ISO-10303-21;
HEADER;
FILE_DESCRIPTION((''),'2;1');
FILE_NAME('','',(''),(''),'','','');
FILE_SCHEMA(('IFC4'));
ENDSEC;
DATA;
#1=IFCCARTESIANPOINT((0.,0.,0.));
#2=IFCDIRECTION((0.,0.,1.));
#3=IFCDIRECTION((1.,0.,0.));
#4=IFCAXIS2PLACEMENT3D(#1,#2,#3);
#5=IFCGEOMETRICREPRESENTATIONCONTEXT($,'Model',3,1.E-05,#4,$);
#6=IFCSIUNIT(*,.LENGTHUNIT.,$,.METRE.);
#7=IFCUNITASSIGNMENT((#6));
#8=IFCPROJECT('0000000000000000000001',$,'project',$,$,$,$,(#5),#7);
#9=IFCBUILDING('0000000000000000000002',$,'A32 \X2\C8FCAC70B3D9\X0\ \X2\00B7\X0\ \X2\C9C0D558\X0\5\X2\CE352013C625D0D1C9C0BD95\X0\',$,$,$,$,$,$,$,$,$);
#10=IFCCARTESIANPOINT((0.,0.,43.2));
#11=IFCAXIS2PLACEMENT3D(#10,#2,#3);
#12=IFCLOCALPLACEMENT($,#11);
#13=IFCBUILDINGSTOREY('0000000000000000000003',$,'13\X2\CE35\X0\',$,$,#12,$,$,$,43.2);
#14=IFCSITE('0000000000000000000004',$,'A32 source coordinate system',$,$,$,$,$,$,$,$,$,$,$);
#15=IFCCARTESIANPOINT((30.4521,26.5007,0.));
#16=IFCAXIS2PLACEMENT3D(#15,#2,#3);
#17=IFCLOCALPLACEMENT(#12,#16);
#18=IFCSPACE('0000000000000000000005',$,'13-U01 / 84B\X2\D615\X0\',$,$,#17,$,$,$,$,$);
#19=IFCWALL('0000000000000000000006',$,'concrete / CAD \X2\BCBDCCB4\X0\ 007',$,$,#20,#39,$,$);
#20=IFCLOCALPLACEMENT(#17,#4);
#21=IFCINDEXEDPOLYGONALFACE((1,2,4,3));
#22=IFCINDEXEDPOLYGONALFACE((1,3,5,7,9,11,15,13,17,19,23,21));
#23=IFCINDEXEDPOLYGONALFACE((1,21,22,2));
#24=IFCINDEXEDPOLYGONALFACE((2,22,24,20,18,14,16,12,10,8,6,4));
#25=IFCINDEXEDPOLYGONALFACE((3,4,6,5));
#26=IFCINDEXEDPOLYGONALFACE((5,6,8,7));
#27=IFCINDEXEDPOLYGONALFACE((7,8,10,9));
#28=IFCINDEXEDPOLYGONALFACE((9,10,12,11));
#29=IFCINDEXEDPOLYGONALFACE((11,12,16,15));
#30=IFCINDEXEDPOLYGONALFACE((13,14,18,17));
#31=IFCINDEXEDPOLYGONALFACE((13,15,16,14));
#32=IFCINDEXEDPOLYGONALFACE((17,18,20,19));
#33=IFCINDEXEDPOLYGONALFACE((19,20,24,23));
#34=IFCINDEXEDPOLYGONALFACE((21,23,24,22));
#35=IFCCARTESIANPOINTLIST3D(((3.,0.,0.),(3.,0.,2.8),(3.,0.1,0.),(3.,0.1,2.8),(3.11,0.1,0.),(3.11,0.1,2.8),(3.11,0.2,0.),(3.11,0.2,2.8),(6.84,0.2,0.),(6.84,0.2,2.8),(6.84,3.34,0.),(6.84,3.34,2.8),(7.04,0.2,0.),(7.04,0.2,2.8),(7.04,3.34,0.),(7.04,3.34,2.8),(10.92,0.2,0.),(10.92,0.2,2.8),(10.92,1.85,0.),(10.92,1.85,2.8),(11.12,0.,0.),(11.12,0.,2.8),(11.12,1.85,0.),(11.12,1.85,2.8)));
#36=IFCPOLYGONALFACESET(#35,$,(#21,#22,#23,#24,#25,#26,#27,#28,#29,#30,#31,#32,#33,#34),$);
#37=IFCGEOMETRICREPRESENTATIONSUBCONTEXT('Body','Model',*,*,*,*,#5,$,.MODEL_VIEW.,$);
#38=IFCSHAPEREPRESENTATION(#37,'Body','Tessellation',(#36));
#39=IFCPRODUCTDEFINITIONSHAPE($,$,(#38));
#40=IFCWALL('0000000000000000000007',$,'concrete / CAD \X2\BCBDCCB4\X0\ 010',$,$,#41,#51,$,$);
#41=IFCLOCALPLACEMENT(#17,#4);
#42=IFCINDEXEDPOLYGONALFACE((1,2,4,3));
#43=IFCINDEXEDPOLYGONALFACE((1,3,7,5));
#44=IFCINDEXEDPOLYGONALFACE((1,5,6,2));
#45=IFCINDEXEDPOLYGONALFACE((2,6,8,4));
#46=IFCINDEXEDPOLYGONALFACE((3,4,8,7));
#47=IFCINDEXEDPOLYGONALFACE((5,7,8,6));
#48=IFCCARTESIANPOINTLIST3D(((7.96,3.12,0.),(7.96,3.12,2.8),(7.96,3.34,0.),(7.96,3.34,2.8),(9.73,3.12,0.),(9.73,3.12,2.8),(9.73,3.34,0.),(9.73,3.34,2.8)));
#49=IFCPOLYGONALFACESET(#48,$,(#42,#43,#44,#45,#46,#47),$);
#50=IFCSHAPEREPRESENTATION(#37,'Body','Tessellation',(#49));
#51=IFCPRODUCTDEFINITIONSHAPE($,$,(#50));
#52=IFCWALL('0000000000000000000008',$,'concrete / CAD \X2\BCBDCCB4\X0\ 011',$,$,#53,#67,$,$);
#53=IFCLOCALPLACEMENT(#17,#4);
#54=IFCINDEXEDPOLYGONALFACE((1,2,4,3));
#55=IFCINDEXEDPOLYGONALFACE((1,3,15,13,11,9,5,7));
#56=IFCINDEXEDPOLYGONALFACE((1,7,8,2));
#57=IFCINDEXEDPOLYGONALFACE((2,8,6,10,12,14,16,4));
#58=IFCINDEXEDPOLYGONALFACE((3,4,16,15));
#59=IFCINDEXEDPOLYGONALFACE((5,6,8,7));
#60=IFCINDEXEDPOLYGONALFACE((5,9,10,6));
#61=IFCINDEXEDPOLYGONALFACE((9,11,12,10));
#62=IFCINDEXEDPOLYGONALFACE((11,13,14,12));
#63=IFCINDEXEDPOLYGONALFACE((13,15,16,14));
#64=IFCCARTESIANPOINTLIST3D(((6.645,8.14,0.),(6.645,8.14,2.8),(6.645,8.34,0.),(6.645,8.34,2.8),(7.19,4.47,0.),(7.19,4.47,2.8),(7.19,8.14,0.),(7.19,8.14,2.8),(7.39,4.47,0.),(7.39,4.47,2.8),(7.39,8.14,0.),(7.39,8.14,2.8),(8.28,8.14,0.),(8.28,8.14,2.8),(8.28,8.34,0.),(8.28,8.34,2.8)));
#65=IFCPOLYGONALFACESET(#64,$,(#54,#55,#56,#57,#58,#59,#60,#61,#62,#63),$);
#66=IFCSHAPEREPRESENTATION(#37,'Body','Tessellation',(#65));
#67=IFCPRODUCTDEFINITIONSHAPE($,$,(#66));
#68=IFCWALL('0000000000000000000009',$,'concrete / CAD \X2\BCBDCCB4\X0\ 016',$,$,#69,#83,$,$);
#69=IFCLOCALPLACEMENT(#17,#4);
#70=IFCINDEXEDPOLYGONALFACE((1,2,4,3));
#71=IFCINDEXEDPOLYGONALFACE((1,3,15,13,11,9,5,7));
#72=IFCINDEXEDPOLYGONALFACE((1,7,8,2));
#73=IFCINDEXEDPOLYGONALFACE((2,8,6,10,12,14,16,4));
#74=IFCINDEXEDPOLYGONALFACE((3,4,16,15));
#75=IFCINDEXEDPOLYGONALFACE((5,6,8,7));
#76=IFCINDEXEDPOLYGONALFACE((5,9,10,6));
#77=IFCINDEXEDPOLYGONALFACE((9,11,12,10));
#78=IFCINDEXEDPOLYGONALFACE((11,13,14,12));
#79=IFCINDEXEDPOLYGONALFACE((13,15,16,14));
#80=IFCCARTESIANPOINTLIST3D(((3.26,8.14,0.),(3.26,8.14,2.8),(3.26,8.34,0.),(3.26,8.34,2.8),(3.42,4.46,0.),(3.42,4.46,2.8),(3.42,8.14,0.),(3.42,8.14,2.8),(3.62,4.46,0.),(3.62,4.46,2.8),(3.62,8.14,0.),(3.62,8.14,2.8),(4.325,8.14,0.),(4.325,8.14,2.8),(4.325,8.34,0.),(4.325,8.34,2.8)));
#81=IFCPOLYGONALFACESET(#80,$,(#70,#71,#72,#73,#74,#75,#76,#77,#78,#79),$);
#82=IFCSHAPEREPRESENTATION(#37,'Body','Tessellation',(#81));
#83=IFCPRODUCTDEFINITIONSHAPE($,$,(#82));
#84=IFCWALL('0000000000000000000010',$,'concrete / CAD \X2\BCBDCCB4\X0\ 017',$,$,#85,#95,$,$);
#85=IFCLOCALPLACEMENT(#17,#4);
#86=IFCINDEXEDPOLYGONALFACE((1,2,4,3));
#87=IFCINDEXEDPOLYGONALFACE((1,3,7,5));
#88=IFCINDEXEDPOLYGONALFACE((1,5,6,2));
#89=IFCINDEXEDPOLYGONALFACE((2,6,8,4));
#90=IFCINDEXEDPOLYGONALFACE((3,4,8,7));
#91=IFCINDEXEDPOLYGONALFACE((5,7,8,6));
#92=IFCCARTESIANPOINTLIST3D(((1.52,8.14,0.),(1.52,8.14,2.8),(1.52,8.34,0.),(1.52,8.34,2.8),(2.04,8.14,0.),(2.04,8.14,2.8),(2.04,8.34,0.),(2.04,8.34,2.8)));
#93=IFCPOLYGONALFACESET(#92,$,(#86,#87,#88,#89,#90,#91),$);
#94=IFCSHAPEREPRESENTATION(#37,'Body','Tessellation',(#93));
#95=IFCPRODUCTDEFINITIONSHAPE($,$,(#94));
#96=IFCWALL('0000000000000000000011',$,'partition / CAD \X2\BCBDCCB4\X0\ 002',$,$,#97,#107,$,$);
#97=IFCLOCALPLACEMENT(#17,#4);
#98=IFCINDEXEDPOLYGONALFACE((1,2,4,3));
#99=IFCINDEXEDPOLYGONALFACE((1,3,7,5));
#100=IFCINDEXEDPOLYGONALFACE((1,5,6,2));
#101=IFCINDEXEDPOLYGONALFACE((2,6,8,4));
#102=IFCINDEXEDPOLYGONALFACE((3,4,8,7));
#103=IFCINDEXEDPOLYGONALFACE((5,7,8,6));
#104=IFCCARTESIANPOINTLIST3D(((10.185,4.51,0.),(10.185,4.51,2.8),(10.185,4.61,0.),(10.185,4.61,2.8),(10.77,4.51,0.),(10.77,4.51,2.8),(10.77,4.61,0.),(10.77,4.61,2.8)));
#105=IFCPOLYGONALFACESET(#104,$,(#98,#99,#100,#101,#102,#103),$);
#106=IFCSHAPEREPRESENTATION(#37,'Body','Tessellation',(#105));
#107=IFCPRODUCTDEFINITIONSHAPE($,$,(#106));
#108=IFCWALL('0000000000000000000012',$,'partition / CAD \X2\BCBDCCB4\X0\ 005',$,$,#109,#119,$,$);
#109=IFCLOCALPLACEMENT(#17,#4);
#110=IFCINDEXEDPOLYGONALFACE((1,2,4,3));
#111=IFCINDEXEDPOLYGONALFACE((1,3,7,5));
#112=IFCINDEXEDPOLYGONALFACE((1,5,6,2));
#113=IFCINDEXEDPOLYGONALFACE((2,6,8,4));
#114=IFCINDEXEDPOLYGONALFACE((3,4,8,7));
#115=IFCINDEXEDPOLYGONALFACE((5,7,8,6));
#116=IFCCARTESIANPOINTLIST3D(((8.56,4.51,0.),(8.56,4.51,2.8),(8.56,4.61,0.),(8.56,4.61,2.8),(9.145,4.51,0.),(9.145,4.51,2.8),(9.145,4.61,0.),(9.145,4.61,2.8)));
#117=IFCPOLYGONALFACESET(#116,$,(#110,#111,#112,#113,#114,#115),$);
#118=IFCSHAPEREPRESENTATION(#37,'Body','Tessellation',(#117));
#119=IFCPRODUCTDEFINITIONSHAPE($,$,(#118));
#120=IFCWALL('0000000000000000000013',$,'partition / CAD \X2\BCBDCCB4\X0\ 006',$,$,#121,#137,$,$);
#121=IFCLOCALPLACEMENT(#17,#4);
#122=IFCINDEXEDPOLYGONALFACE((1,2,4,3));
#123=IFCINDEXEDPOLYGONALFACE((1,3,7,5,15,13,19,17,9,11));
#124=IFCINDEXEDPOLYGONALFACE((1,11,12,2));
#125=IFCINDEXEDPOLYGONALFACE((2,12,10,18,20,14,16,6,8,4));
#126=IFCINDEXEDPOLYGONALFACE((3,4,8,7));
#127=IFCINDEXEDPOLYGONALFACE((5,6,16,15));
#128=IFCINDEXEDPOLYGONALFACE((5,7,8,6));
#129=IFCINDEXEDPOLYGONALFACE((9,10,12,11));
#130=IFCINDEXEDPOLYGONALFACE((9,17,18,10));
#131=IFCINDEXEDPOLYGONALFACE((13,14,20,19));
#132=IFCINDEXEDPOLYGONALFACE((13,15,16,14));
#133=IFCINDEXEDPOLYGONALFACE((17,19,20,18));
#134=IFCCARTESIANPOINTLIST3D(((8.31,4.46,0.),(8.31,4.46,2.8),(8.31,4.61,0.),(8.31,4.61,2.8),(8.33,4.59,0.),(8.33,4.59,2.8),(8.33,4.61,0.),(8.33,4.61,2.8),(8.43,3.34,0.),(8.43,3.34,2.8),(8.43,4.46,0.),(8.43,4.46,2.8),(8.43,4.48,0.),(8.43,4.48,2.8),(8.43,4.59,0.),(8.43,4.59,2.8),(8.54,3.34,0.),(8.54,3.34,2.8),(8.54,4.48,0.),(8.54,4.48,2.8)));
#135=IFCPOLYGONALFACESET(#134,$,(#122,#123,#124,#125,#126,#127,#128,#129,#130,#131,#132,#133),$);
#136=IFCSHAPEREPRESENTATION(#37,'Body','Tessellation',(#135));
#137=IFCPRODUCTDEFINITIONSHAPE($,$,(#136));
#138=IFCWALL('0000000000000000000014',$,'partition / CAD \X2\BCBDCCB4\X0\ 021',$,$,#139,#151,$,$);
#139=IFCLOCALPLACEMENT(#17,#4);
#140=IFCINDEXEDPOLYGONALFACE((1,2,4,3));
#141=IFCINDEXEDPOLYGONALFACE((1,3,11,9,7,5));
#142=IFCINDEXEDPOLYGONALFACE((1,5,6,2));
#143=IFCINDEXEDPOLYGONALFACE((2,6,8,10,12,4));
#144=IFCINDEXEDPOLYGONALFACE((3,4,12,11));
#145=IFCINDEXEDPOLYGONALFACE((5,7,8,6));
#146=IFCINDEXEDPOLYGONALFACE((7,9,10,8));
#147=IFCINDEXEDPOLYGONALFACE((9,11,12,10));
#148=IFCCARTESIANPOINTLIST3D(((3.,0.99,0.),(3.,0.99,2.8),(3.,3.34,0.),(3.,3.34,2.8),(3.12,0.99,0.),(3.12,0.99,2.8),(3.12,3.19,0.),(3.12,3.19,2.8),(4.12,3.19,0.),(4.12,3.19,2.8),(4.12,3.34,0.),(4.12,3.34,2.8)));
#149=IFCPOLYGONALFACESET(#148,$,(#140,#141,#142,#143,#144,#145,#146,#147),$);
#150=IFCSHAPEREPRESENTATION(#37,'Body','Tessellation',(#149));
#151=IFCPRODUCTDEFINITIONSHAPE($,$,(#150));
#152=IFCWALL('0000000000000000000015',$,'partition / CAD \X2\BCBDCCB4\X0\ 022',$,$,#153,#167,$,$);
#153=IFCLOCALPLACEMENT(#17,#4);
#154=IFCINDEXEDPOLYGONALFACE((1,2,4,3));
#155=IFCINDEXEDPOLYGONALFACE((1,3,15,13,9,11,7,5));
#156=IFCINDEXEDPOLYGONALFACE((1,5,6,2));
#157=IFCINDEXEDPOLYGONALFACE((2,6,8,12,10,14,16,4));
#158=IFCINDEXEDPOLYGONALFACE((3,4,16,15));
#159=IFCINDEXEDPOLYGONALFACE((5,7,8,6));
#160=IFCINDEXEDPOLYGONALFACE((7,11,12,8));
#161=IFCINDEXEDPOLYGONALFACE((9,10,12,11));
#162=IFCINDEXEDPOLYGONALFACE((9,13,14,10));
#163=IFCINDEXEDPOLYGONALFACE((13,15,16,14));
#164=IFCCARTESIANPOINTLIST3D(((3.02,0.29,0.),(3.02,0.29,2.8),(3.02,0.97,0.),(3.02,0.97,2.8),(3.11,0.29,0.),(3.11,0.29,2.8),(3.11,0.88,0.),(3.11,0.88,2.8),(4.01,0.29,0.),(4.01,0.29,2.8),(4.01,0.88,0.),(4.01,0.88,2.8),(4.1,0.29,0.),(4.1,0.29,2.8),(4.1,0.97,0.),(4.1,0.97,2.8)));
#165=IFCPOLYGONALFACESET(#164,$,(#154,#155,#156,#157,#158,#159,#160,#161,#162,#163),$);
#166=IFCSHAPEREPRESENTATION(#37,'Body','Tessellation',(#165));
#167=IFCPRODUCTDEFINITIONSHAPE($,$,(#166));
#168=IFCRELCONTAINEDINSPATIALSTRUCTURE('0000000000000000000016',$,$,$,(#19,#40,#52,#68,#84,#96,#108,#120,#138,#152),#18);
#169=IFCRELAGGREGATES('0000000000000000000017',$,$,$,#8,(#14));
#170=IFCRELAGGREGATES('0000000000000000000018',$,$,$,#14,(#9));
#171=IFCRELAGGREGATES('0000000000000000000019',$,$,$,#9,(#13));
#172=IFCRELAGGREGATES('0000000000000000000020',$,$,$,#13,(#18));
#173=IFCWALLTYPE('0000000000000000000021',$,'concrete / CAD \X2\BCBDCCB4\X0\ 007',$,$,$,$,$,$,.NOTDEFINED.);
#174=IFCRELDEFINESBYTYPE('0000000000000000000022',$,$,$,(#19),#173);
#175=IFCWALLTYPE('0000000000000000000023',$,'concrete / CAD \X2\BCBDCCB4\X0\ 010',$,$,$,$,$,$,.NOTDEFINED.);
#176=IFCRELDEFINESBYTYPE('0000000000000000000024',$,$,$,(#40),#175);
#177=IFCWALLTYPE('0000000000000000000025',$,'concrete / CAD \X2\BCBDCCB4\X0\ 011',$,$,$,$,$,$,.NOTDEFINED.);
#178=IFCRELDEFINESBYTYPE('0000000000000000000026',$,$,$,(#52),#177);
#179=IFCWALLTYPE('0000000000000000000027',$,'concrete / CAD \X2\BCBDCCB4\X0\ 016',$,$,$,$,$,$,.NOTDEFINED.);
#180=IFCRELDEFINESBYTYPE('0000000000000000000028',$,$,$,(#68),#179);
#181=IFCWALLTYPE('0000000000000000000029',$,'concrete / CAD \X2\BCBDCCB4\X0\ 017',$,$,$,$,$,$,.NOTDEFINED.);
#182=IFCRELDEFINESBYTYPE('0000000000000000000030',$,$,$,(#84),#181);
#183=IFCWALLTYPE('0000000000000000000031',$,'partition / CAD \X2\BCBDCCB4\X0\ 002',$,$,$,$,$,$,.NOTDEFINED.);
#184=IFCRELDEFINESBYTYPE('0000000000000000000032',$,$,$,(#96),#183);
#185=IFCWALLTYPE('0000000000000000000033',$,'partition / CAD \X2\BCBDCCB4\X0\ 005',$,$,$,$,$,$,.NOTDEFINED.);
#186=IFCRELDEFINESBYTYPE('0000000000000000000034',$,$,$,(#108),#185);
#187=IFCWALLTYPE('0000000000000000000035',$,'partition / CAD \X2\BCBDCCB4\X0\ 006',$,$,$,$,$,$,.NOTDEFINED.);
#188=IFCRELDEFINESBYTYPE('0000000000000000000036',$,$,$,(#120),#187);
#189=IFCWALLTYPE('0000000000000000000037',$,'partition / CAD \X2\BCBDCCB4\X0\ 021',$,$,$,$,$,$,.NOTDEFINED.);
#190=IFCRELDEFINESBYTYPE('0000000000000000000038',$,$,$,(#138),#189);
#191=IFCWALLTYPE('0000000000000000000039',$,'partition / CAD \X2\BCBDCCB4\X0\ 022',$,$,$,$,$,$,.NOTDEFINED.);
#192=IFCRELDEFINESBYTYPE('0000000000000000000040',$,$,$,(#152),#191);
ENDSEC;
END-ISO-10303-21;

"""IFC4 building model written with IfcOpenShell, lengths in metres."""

from ifc_helpers import new_model, si_unit, frame, origin, origin_with_axes, place, context, subcontext, project, spatial, polyline, outline, extrude, source, transform, mapped, type_object, type_shapes, element, save


model = new_model("IFC4")

# Units and contexts
model_context = context("Model", 3, precision=1e-05, world=origin_with_axes())
body_context = subcontext(model_context, "Body", "Model", "MODEL_VIEW")
ifc_project = project(units=[si_unit("LENGTHUNIT", "METRE")], contexts=[model_context])

# Site, building, storey, space
site = spatial("IfcSite", under=ifc_project, Name="A32 source coordinate system")
building = spatial("IfcBuilding", under=site, Name="A32 주거동 · 지하5층–옥탑지붕")
storey_placement = place(None, frame((0.0, 0.0, 43.2), z_axis=(0.0, 0.0, 1.0), x_axis=(1.0, 0.0, 0.0)))
storey = spatial("IfcBuildingStorey", under=building, at=storey_placement, Name="13층", Elevation=43.2)
space_1_placement = place(storey_placement, frame((30.4521, 26.5007, 0.0), z_axis=(0.0, 0.0, 1.0), x_axis=(1.0, 0.0, 0.0)))
space_1 = spatial("IfcSpace", under=storey, at=space_1_placement, Name="13-U01 / 84B형")

# Walls
wall_type_1 = type_object("IfcWallType", Name="concrete / CAD 벽체 007", PredefinedType="NOTDEFINED")
shared_shape_1 = source(origin(), body_context, "Body", "SweptSolid", [
    extrude(outline(polyline([(3.0, 0.0), (3.0, 0.1), (3.11, 0.1), (3.11, 0.2), (6.84, 0.2), (6.84, 3.34), (7.04, 3.34), (7.04, 0.2), (10.92, 0.2), (10.92, 1.85), (11.12, 1.85), (11.12, 0.0), (3.0, 0.0)])), origin(), (0.0, 0.0, 1.0), 2.8),
])
type_shapes(wall_type_1, [shared_shape_1])
wall_1_placement = place(space_1_placement, origin_with_axes())
element("IfcWall", 1, at=wall_1_placement, inside=space_1, type_object=wall_type_1, Name="concrete / CAD 벽체 007", context=body_context, shape_type="MappedRepresentation", body=[
    mapped(shared_shape_1, transform((0.0, 0.0, 0.0), scale=1.0)),
])
wall_type_2 = type_object("IfcWallType", Name="concrete / CAD 벽체 010", PredefinedType="NOTDEFINED")
shared_shape_2 = source(origin(), body_context, "Body", "SweptSolid", [
    extrude(outline(polyline([(7.96, 3.12), (7.96, 3.34), (9.73, 3.34), (9.73, 3.12), (7.96, 3.12)])), origin(), (0.0, 0.0, 1.0), 2.8),
])
type_shapes(wall_type_2, [shared_shape_2])
wall_2_placement = place(space_1_placement, origin_with_axes())
element("IfcWall", 2, at=wall_2_placement, inside=space_1, type_object=wall_type_2, Name="concrete / CAD 벽체 010", context=body_context, shape_type="MappedRepresentation", body=[
    mapped(shared_shape_2, transform((0.0, 0.0, 0.0), scale=1.0)),
])
wall_type_3 = type_object("IfcWallType", Name="concrete / CAD 벽체 011", PredefinedType="NOTDEFINED")
shared_shape_3 = source(origin(), body_context, "Body", "SweptSolid", [
    extrude(outline(polyline([(7.19, 8.14), (6.645, 8.14), (6.645, 8.34), (8.28, 8.34), (8.28, 8.14), (7.39, 8.14), (7.39, 4.47), (7.19, 4.47), (7.19, 8.14)])), origin(), (0.0, 0.0, 1.0), 2.8),
])
type_shapes(wall_type_3, [shared_shape_3])
wall_3_placement = place(space_1_placement, origin_with_axes())
element("IfcWall", 3, at=wall_3_placement, inside=space_1, type_object=wall_type_3, Name="concrete / CAD 벽체 011", context=body_context, shape_type="MappedRepresentation", body=[
    mapped(shared_shape_3, transform((0.0, 0.0, 0.0), scale=1.0)),
])
wall_type_4 = type_object("IfcWallType", Name="concrete / CAD 벽체 016", PredefinedType="NOTDEFINED")
shared_shape_4 = source(origin(), body_context, "Body", "SweptSolid", [
    extrude(outline(polyline([(3.26, 8.14), (3.26, 8.34), (4.325, 8.34), (4.325, 8.14), (3.62, 8.14), (3.62, 4.46), (3.42, 4.46), (3.42, 8.14), (3.26, 8.14)])), origin(), (0.0, 0.0, 1.0), 2.8),
])
type_shapes(wall_type_4, [shared_shape_4])
wall_4_placement = place(space_1_placement, origin_with_axes())
element("IfcWall", 4, at=wall_4_placement, inside=space_1, type_object=wall_type_4, Name="concrete / CAD 벽체 016", context=body_context, shape_type="MappedRepresentation", body=[
    mapped(shared_shape_4, transform((0.0, 0.0, 0.0), scale=1.0)),
])
wall_type_5 = type_object("IfcWallType", Name="concrete / CAD 벽체 017", PredefinedType="NOTDEFINED")
shared_shape_5 = source(origin(), body_context, "Body", "SweptSolid", [
    extrude(outline(polyline([(1.52, 8.34), (2.04, 8.34), (2.04, 8.14), (1.52, 8.14), (1.52, 8.34)])), origin(), (0.0, 0.0, 1.0), 2.8),
])
type_shapes(wall_type_5, [shared_shape_5])
wall_5_placement = place(space_1_placement, origin_with_axes())
element("IfcWall", 5, at=wall_5_placement, inside=space_1, type_object=wall_type_5, Name="concrete / CAD 벽체 017", context=body_context, shape_type="MappedRepresentation", body=[
    mapped(shared_shape_5, transform((0.0, 0.0, 0.0), scale=1.0)),
])
wall_type_6 = type_object("IfcWallType", Name="partition / CAD 벽체 002", PredefinedType="NOTDEFINED")
shared_shape_6 = source(origin(), body_context, "Body", "SweptSolid", [
    extrude(outline(polyline([(10.185, 4.51), (10.185, 4.61), (10.77, 4.61), (10.77, 4.51), (10.185, 4.51)])), origin(), (0.0, 0.0, 1.0), 2.8),
])
type_shapes(wall_type_6, [shared_shape_6])
wall_6_placement = place(space_1_placement, origin_with_axes())
element("IfcWall", 6, at=wall_6_placement, inside=space_1, type_object=wall_type_6, Name="partition / CAD 벽체 002", context=body_context, shape_type="MappedRepresentation", body=[
    mapped(shared_shape_6, transform((0.0, 0.0, 0.0), scale=1.0)),
])
wall_type_7 = type_object("IfcWallType", Name="partition / CAD 벽체 005", PredefinedType="NOTDEFINED")
shared_shape_7 = source(origin(), body_context, "Body", "SweptSolid", [
    extrude(outline(polyline([(8.56, 4.51), (8.56, 4.61), (9.145, 4.61), (9.145, 4.51), (8.56, 4.51)])), origin(), (0.0, 0.0, 1.0), 2.8),
])
type_shapes(wall_type_7, [shared_shape_7])
wall_7_placement = place(space_1_placement, origin_with_axes())
element("IfcWall", 7, at=wall_7_placement, inside=space_1, type_object=wall_type_7, Name="partition / CAD 벽체 005", context=body_context, shape_type="MappedRepresentation", body=[
    mapped(shared_shape_7, transform((0.0, 0.0, 0.0), scale=1.0)),
])
wall_type_8 = type_object("IfcWallType", Name="partition / CAD 벽체 006", PredefinedType="NOTDEFINED")
shared_shape_8 = source(origin(), body_context, "Body", "SweptSolid", [
    extrude(outline(polyline([(8.43, 4.46), (8.31, 4.46), (8.31, 4.61), (8.33, 4.61), (8.33, 4.59), (8.43, 4.59), (8.43, 4.48), (8.54, 4.48), (8.54, 3.34), (8.43, 3.34), (8.43, 4.46)])), origin(), (0.0, 0.0, 1.0), 2.8),
])
type_shapes(wall_type_8, [shared_shape_8])
wall_8_placement = place(space_1_placement, origin_with_axes())
element("IfcWall", 8, at=wall_8_placement, inside=space_1, type_object=wall_type_8, Name="partition / CAD 벽체 006", context=body_context, shape_type="MappedRepresentation", body=[
    mapped(shared_shape_8, transform((0.0, 0.0, 0.0), scale=1.0)),
])
wall_type_9 = type_object("IfcWallType", Name="partition / CAD 벽체 021", PredefinedType="NOTDEFINED")
shared_shape_9 = source(origin(), body_context, "Body", "SweptSolid", [
    extrude(outline(polyline([(4.12, 3.34), (4.12, 3.19), (3.12, 3.19), (3.12, 0.99), (3.0, 0.99), (3.0, 3.34), (4.12, 3.34)])), origin(), (0.0, 0.0, 1.0), 2.8),
])
type_shapes(wall_type_9, [shared_shape_9])
wall_9_placement = place(space_1_placement, origin_with_axes())
element("IfcWall", 9, at=wall_9_placement, inside=space_1, type_object=wall_type_9, Name="partition / CAD 벽체 021", context=body_context, shape_type="MappedRepresentation", body=[
    mapped(shared_shape_9, transform((0.0, 0.0, 0.0), scale=1.0)),
])
wall_type_10 = type_object("IfcWallType", Name="partition / CAD 벽체 022", PredefinedType="NOTDEFINED")
shared_shape_10 = source(origin(), body_context, "Body", "SweptSolid", [
    extrude(outline(polyline([(4.1, 0.97), (4.1, 0.29), (4.01, 0.29), (4.01, 0.88), (3.11, 0.88), (3.11, 0.29), (3.02, 0.29), (3.02, 0.97), (4.1, 0.97)])), origin(), (0.0, 0.0, 1.0), 2.8),
])
type_shapes(wall_type_10, [shared_shape_10])
wall_10_placement = place(space_1_placement, origin_with_axes())
element("IfcWall", 10, at=wall_10_placement, inside=space_1, type_object=wall_type_10, Name="partition / CAD 벽체 022", context=body_context, shape_type="MappedRepresentation", body=[
    mapped(shared_shape_10, transform((0.0, 0.0, 0.0), scale=1.0)),
])

save(model, "model.ifc")
